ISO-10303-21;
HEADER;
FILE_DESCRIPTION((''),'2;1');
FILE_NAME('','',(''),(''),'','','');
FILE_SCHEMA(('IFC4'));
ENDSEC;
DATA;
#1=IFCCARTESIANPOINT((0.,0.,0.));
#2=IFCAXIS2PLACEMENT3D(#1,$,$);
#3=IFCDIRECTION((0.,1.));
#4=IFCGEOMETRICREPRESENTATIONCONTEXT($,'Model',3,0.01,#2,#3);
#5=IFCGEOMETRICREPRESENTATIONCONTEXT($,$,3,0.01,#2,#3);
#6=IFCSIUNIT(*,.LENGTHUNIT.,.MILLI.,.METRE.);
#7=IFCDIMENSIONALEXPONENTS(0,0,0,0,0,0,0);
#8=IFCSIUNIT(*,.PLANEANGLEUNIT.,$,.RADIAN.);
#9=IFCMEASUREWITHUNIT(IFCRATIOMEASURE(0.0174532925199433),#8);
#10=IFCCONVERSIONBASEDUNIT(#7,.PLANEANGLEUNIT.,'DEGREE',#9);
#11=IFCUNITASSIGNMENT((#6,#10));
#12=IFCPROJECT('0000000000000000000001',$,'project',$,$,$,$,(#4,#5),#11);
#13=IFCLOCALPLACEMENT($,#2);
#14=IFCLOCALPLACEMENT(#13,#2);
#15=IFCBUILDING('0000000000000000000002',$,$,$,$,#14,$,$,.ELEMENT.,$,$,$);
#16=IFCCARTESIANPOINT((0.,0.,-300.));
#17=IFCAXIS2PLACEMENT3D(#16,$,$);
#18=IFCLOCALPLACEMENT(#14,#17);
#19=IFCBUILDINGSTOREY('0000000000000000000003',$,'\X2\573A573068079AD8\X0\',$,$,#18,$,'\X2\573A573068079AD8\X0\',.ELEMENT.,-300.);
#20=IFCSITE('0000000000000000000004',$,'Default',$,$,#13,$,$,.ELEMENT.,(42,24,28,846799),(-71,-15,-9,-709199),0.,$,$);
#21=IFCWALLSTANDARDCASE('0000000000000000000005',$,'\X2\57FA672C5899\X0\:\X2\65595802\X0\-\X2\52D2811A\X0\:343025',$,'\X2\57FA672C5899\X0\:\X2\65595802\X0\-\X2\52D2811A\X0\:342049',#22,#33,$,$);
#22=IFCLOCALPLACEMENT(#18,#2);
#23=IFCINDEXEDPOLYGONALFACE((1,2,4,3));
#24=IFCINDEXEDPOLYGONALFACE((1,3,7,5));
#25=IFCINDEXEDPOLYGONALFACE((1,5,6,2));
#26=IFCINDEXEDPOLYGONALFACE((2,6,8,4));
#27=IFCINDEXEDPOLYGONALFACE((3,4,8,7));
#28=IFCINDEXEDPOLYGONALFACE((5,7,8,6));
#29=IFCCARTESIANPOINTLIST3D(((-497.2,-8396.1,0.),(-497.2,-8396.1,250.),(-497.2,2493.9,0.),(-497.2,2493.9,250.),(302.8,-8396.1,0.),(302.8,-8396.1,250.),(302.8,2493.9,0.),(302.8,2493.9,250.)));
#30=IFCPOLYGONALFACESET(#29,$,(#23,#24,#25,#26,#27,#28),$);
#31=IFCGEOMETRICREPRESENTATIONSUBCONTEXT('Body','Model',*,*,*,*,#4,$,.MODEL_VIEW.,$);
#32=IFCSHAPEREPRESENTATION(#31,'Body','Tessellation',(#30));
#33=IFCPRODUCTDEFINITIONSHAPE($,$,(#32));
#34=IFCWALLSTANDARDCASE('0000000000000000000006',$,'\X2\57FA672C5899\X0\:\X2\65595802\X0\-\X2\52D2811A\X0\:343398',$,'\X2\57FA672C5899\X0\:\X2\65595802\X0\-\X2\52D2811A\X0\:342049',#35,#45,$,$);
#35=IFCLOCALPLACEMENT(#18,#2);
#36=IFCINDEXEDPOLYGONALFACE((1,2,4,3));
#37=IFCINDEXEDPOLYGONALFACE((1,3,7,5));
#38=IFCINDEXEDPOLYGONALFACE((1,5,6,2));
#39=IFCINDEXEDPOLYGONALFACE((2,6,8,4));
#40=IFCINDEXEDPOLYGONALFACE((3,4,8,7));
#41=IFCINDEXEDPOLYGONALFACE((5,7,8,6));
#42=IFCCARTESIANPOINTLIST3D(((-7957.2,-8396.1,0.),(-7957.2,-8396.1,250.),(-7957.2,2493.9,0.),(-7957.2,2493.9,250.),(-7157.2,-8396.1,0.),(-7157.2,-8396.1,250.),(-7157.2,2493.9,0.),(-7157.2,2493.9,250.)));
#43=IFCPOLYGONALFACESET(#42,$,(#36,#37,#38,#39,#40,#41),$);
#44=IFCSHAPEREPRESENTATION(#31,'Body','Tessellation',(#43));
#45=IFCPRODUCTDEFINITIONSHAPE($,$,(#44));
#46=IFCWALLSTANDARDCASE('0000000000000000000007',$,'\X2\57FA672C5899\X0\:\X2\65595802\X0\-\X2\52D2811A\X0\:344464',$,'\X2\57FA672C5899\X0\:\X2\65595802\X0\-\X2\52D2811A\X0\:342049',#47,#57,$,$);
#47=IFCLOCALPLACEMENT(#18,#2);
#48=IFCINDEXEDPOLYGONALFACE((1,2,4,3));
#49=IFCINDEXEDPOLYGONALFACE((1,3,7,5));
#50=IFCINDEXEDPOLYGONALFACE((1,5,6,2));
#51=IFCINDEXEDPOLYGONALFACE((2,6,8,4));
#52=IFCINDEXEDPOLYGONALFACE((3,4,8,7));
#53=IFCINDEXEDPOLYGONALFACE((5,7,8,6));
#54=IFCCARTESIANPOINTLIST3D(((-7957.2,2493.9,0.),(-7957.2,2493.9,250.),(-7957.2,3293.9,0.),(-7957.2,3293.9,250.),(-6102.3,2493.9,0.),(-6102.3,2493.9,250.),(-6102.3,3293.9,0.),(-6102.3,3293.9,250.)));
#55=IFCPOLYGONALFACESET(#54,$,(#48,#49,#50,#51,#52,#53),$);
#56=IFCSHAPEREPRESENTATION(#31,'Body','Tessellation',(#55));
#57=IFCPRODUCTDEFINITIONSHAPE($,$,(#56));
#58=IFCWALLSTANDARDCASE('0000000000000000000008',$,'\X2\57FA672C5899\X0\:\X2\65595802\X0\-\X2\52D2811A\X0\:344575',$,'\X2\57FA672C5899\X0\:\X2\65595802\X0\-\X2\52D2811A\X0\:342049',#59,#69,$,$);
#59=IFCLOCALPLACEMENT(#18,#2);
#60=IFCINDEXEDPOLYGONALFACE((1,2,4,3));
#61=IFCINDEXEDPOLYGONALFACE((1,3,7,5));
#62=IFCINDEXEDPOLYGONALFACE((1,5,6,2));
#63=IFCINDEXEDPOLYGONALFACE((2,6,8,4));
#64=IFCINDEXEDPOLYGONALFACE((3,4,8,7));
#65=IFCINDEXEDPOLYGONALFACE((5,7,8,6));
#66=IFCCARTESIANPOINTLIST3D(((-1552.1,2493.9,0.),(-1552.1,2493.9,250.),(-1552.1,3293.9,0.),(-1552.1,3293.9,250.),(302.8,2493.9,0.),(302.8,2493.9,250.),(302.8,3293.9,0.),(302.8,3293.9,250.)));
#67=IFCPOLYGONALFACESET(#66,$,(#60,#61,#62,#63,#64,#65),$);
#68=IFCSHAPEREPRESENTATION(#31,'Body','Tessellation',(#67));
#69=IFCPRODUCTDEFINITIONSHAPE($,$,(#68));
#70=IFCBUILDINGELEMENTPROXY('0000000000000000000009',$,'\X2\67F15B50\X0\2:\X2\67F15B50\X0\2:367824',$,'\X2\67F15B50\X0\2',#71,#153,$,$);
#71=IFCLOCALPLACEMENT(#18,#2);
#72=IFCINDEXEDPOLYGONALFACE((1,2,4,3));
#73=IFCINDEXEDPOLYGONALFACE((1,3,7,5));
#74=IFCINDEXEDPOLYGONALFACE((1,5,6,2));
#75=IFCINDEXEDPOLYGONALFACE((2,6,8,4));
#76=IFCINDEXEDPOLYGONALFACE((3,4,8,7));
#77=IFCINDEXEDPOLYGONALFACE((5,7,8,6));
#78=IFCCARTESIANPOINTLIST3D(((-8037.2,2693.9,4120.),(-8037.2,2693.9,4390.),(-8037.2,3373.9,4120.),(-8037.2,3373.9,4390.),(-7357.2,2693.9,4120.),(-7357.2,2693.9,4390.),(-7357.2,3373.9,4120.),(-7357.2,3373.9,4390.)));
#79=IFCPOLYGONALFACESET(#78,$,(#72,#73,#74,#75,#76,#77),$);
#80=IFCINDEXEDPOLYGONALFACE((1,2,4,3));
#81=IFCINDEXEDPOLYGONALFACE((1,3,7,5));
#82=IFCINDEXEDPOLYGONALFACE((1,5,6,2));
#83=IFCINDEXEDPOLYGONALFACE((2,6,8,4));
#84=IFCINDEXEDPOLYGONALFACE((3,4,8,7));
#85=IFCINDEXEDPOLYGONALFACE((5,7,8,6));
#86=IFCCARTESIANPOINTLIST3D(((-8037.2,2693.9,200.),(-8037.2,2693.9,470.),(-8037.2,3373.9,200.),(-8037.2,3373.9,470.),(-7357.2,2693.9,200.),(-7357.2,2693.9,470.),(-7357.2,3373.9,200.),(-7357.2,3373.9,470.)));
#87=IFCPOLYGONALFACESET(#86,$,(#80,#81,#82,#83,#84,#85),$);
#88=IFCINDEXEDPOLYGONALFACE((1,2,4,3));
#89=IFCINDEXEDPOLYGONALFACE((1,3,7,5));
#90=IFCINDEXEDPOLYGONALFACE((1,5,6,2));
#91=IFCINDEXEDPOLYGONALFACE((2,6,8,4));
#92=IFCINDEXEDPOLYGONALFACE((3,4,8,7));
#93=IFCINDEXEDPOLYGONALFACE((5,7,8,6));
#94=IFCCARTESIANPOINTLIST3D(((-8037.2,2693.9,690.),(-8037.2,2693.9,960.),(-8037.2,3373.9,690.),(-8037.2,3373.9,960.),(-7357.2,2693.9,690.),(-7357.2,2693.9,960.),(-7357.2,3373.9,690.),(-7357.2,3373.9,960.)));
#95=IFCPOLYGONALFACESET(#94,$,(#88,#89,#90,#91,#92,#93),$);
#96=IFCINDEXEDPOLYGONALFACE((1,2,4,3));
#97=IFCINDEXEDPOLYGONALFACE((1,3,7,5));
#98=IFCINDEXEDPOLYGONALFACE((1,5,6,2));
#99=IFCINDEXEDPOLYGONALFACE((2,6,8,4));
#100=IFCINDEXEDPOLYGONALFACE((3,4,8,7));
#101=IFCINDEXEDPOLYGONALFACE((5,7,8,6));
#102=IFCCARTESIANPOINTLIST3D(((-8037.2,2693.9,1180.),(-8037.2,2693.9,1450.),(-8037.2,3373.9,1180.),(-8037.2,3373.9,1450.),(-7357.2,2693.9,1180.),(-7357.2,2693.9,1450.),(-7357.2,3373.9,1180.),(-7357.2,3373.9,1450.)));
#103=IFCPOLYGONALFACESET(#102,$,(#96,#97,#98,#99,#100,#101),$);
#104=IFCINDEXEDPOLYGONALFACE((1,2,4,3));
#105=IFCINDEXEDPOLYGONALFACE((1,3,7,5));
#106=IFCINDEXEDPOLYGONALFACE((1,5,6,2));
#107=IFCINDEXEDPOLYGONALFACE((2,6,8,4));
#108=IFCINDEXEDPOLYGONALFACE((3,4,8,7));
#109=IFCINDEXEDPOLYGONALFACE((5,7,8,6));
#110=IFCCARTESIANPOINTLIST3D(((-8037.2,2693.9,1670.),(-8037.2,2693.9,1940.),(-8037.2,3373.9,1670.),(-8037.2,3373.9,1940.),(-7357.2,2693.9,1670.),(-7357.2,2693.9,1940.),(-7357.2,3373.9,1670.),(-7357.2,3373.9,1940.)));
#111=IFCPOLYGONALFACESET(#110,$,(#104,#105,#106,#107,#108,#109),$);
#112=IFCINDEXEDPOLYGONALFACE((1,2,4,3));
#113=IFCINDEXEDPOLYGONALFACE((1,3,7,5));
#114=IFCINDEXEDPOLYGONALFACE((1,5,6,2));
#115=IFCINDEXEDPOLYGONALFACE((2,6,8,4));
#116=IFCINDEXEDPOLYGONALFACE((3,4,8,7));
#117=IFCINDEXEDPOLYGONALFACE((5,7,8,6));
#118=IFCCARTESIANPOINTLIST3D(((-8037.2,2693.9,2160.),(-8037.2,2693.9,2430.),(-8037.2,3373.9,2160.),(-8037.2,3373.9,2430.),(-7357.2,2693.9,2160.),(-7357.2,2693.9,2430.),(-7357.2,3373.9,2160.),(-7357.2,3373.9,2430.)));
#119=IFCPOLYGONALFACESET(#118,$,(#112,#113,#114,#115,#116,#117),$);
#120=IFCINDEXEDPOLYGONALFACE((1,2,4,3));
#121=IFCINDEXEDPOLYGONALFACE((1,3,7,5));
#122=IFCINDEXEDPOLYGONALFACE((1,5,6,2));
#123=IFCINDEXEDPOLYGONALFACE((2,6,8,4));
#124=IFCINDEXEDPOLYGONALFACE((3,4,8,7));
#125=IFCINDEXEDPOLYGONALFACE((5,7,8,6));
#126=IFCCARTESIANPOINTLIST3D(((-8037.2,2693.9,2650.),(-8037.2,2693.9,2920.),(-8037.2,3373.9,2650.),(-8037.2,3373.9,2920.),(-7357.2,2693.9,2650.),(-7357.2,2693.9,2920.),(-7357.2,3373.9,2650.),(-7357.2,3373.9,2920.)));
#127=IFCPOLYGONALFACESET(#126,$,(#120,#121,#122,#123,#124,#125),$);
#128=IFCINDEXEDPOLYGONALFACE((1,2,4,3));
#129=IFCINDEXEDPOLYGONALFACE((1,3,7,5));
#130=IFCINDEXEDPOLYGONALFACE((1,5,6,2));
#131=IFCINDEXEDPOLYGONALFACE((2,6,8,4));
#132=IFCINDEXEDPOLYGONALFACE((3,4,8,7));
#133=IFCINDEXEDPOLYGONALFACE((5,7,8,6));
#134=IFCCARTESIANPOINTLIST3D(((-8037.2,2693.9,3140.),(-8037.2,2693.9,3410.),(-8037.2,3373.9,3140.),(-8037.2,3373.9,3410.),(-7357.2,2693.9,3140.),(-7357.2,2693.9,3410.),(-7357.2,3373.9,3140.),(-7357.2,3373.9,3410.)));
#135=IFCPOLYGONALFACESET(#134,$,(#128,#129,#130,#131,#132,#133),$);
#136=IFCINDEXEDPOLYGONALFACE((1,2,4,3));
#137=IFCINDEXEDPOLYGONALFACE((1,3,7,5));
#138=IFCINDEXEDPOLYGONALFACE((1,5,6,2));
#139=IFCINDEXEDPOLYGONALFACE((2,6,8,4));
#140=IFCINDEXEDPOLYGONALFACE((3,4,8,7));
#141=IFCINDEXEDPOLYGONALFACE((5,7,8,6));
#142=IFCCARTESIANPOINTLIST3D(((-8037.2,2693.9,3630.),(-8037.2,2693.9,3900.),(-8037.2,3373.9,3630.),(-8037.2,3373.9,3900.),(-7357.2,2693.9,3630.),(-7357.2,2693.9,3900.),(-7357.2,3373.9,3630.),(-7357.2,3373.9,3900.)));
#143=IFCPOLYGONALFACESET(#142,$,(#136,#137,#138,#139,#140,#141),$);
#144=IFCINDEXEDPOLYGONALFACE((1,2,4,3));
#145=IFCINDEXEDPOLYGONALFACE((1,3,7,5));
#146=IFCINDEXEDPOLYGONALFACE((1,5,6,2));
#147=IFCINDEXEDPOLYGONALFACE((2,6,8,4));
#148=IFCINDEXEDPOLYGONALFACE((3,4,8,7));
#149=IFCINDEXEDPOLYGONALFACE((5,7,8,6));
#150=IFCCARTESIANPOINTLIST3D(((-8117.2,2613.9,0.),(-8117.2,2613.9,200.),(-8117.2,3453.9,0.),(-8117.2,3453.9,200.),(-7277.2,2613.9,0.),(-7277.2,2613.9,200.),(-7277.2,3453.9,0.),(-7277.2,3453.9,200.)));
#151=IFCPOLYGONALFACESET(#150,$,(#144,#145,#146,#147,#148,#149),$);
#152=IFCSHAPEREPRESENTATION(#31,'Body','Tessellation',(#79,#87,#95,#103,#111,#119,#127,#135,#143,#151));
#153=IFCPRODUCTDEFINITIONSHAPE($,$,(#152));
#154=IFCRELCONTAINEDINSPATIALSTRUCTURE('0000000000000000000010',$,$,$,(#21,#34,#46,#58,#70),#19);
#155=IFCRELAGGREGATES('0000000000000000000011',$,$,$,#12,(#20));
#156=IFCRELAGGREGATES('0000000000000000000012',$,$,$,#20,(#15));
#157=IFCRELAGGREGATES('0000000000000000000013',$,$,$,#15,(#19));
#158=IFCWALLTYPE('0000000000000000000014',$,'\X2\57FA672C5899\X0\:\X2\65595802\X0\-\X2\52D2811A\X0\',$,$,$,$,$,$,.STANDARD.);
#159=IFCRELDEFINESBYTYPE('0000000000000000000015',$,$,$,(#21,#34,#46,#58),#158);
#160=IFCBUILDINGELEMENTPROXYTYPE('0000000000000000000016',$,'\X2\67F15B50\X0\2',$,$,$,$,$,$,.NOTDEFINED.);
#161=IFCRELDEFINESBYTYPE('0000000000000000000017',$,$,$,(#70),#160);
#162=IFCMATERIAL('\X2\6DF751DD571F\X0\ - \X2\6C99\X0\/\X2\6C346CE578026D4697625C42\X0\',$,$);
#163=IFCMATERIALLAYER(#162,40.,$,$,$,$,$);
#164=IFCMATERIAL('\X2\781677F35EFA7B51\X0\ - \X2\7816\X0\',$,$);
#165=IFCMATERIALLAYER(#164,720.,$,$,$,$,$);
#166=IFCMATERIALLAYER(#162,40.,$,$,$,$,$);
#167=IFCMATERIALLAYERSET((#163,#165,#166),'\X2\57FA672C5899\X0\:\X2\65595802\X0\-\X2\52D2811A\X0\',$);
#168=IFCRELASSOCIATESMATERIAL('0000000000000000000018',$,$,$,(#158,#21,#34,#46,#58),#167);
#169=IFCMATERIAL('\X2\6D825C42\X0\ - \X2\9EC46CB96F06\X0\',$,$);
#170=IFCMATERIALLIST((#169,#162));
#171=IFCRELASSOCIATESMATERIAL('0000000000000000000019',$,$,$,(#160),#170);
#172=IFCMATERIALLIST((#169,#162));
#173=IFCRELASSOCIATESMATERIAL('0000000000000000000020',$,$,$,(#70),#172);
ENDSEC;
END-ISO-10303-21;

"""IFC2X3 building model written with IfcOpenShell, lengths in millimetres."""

from ifc_helpers import new_model, entity, si_unit, converted_unit, direction, frame, frame_2d, origin, origin_2d_with_axis, place, context, subcontext, project, spatial, polyline, rectangle, extrude, clip, bounded_halfspace, source, transform, mapped, material, material_list, layer, layer_set, layer_usage, type_object, type_shapes, element, save


model = new_model("IFC2X3")

# Units and contexts
model_context = context("Model", 3, precision=0.01, world=origin(), true_north=direction((0.0, 1.0)))
context_of_model = context(None, 3, precision=0.01, world=origin(), true_north=direction((0.0, 1.0)))
body_context = subcontext(model_context, "Body", "Model", "MODEL_VIEW")
ifc_project = project(units=[si_unit("LENGTHUNIT", "METRE", prefix="MILLI"), converted_unit("PLANEANGLEUNIT", "DEGREE", entity("IfcRatioMeasure", 0.0174532925199433), si_unit("PLANEANGLEUNIT", "RADIAN"), dimensions=[0, 0, 0, 0, 0, 0, 0])], contexts=[model_context, context_of_model])

# Site, building, storey
site_placement = place(None, origin())
site = spatial("IfcSite", under=ifc_project, at=site_placement, Name="Default", CompositionType="ELEMENT", RefLatitude=(42, 24, 28, 846799), RefLongitude=(-71, -15, -9, -709199), RefElevation=0.0)
building_placement = place(site_placement, origin())
building = spatial("IfcBuilding", under=site, at=building_placement, CompositionType="ELEMENT")
storey_placement = place(building_placement, frame((0.0, 0.0, -300.0)))
storey = spatial("IfcBuildingStorey", under=building, at=storey_placement, Name="场地标高", LongName="场地标高", CompositionType="ELEMENT", Elevation=-300.0)

# Walls
ifc_material_1 = material(Name="混凝土 - 沙/水泥砂浆面层")
ifc_layer_1 = layer(ifc_material_1, 40.0)
ifc_material_2 = material(Name="砖石建筑 - 砖")
ifc_layer_2 = layer(ifc_material_2, 720.0)
ifc_layer_3 = layer(ifc_material_1, 40.0)
ifc_layer_set = layer_set([ifc_layer_1, ifc_layer_2, ifc_layer_3], Name="基本墙:教堂-勒脚")
ifc_layer_usage_1 = layer_usage(ifc_layer_set, "AXIS2", "NEGATIVE", 400.0)
wall_type = type_object("IfcWallType", Name="基本墙:教堂-勒脚", PredefinedType="STANDARD", material=ifc_layer_set)
wall_1_placement = place(storey_placement, frame((-97.2, -8396.1, 0.0), z_axis=(0.0, 0.0, 1.0), x_axis=(0.0, 1.0, 0.0)))
element("IfcWallStandardCase", 1, at=wall_1_placement, inside=storey, type_object=wall_type, material=ifc_layer_usage_1, Name="基本墙:教堂-勒脚:343025", ObjectType="基本墙:教堂-勒脚:342049", context=body_context, shape_type="Clipping", body=[
    clip(extrude(rectangle(XDim=10890.0, YDim=800.0, at=frame_2d((5445.0, 0.0), x_axis=(-1.0, 0.0))), origin(), (0.0, 0.0, 1.0), 250.0), bounded_halfspace(frame((0.0, -400.0, 250.0), z_axis=(0.0, 0.0, -1.0), x_axis=(-1.0, 0.0, 0.0)), True, frame((0.0, -400.0, 250.0)), polyline([(0.0, 0.0), (10890.0, 0.0), (10890.0, 800.0), (0.0, 800.0), (0.0, 0.0)]))),
])
ifc_layer_usage_2 = layer_usage(ifc_layer_set, "AXIS2", "NEGATIVE", 400.0)
wall_2_placement = place(storey_placement, frame((-7557.2, 2493.9, 0.0), z_axis=(0.0, 0.0, 1.0), x_axis=(0.0, -1.0, 0.0)))
element("IfcWallStandardCase", 2, at=wall_2_placement, inside=storey, type_object=wall_type, material=ifc_layer_usage_2, Name="基本墙:教堂-勒脚:343398", ObjectType="基本墙:教堂-勒脚:342049", context=body_context, shape_type="Clipping", body=[
    clip(extrude(rectangle(XDim=10890.0, YDim=800.0, at=frame_2d((5445.0, 0.0), x_axis=(-1.0, 0.0))), origin(), (0.0, 0.0, 1.0), 250.0), bounded_halfspace(frame((0.0, -400.0, 250.0), z_axis=(0.0, 0.0, -1.0), x_axis=(1.0, 0.0, 0.0)), True, frame((0.0, -400.0, 250.0)), polyline([(0.0, 0.0), (10890.0, 0.0), (10890.0, 800.0), (0.0, 800.0), (0.0, 0.0)]))),
])
ifc_layer_usage_3 = layer_usage(ifc_layer_set, "AXIS2", "NEGATIVE", 400.0)
wall_3_placement = place(storey_placement, frame((-7957.2, 2893.9, 0.0)))
element("IfcWallStandardCase", 3, at=wall_3_placement, inside=storey, type_object=wall_type, material=ifc_layer_usage_3, Name="基本墙:教堂-勒脚:344464", ObjectType="基本墙:教堂-勒脚:342049", context=body_context, shape_type="Clipping", body=[
    clip(extrude(rectangle(XDim=1854.9, YDim=800.0, at=frame_2d((927.4, 0.0), x_axis=(-1.0, 0.0))), origin(), (0.0, 0.0, 1.0), 250.0), bounded_halfspace(frame((0.0, -400.0, 250.0), z_axis=(0.0, 0.0, -1.0), x_axis=(0.0, -1.0, 0.0)), True, frame((0.0, -400.0, 250.0)), polyline([(0.0, 0.0), (800.0, 0.0), (1854.9, 0.0), (1854.9, 800.0), (0.0, 800.0), (0.0, 0.0)]))),
])
ifc_layer_usage_4 = layer_usage(ifc_layer_set, "AXIS2", "NEGATIVE", 400.0)
wall_4_placement = place(storey_placement, frame((302.8, 2893.9, 0.0), z_axis=(0.0, 0.0, 1.0), x_axis=(-1.0, 0.0, 0.0)))
element("IfcWallStandardCase", 4, at=wall_4_placement, inside=storey, type_object=wall_type, material=ifc_layer_usage_4, Name="基本墙:教堂-勒脚:344575", ObjectType="基本墙:教堂-勒脚:342049", context=body_context, shape_type="Clipping", body=[
    clip(extrude(rectangle(XDim=1854.9, YDim=800.0, at=frame_2d((927.4, 0.0), x_axis=(-1.0, 0.0))), origin(), (0.0, 0.0, 1.0), 250.0), bounded_halfspace(frame((0.0, -400.0, 250.0), z_axis=(0.0, 0.0, -1.0), x_axis=(0.0, 1.0, 0.0)), True, frame((0.0, -400.0, 250.0)), polyline([(0.0, 0.0), (1854.9, 0.0), (1854.9, 800.0), (800.0, 800.0), (0.0, 800.0), (0.0, 0.0)]))),
])

# Building element proxy
ifc_material_3 = material(Name="涂层 - 黄油漆")
ifc_material_list_1 = material_list([ifc_material_3, ifc_material_1])
ifc_material_list_2 = material_list([ifc_material_3, ifc_material_1])
building_element_proxy_type_1 = type_object("IfcBuildingElementProxyType", Name="柱子2", PredefinedType="NOTDEFINED", material=ifc_material_list_2)
shared_shape_1 = source(origin(), body_context, "Body", "SweptSolid", [
    extrude(rectangle(XDim=680.0, YDim=680.0, at=origin_2d_with_axis()), frame((0.0, 0.0, 4120.0), z_axis=(0.0, 0.0, 1.0), x_axis=(0.0, 1.0, 0.0)), (0.0, 0.0, 1.0), 270.0),
    extrude(rectangle(XDim=680.0, YDim=680.0, at=origin_2d_with_axis()), frame((0.0, 0.0, 200.0), z_axis=(0.0, 0.0, 1.0), x_axis=(0.0, 1.0, 0.0)), (0.0, 0.0, 1.0), 270.0),
    extrude(rectangle(XDim=680.0, YDim=680.0, at=origin_2d_with_axis()), frame((0.0, 0.0, 690.0), z_axis=(0.0, 0.0, 1.0), x_axis=(0.0, 1.0, 0.0)), (0.0, 0.0, 1.0), 270.0),
    extrude(rectangle(XDim=680.0, YDim=680.0, at=origin_2d_with_axis()), frame((0.0, 0.0, 1180.0), z_axis=(0.0, 0.0, 1.0), x_axis=(0.0, 1.0, 0.0)), (0.0, 0.0, 1.0), 270.0),
    extrude(rectangle(XDim=680.0, YDim=680.0, at=origin_2d_with_axis()), frame((0.0, 0.0, 1670.0), z_axis=(0.0, 0.0, 1.0), x_axis=(0.0, 1.0, 0.0)), (0.0, 0.0, 1.0), 270.0),
    extrude(rectangle(XDim=680.0, YDim=680.0, at=origin_2d_with_axis()), frame((0.0, 0.0, 2160.0), z_axis=(0.0, 0.0, 1.0), x_axis=(0.0, 1.0, 0.0)), (0.0, 0.0, 1.0), 270.0),
    extrude(rectangle(XDim=680.0, YDim=680.0, at=origin_2d_with_axis()), frame((0.0, 0.0, 2650.0), z_axis=(0.0, 0.0, 1.0), x_axis=(0.0, 1.0, 0.0)), (0.0, 0.0, 1.0), 270.0),
    extrude(rectangle(XDim=680.0, YDim=680.0, at=origin_2d_with_axis()), frame((0.0, 0.0, 3140.0), z_axis=(0.0, 0.0, 1.0), x_axis=(0.0, 1.0, 0.0)), (0.0, 0.0, 1.0), 270.0),
    extrude(rectangle(XDim=680.0, YDim=680.0, at=origin_2d_with_axis()), frame((0.0, 0.0, 3630.0), z_axis=(0.0, 0.0, 1.0), x_axis=(0.0, 1.0, 0.0)), (0.0, 0.0, 1.0), 270.0),
    extrude(rectangle(XDim=840.0, YDim=840.0, at=origin_2d_with_axis()), frame((0.0, 0.0, 0.0), z_axis=(0.0, 0.0, 1.0), x_axis=(0.0, 1.0, 0.0)), (0.0, 0.0, 1.0), 200.0),
])
type_shapes(building_element_proxy_type_1, [shared_shape_1])
proxy_1_placement = place(storey_placement, frame((-7697.2, 3033.9, 0.0)))
element("IfcBuildingElementProxy", 5, at=proxy_1_placement, inside=storey, type_object=building_element_proxy_type_1, material=ifc_material_list_1, Name="柱子2:柱子2:367824", ObjectType="柱子2", context=body_context, shape_type="MappedRepresentation", body=[
    mapped(shared_shape_1, transform((0.0, 0.0, 0.0), scale=1.0)),
])

save(model, "model.ifc")
